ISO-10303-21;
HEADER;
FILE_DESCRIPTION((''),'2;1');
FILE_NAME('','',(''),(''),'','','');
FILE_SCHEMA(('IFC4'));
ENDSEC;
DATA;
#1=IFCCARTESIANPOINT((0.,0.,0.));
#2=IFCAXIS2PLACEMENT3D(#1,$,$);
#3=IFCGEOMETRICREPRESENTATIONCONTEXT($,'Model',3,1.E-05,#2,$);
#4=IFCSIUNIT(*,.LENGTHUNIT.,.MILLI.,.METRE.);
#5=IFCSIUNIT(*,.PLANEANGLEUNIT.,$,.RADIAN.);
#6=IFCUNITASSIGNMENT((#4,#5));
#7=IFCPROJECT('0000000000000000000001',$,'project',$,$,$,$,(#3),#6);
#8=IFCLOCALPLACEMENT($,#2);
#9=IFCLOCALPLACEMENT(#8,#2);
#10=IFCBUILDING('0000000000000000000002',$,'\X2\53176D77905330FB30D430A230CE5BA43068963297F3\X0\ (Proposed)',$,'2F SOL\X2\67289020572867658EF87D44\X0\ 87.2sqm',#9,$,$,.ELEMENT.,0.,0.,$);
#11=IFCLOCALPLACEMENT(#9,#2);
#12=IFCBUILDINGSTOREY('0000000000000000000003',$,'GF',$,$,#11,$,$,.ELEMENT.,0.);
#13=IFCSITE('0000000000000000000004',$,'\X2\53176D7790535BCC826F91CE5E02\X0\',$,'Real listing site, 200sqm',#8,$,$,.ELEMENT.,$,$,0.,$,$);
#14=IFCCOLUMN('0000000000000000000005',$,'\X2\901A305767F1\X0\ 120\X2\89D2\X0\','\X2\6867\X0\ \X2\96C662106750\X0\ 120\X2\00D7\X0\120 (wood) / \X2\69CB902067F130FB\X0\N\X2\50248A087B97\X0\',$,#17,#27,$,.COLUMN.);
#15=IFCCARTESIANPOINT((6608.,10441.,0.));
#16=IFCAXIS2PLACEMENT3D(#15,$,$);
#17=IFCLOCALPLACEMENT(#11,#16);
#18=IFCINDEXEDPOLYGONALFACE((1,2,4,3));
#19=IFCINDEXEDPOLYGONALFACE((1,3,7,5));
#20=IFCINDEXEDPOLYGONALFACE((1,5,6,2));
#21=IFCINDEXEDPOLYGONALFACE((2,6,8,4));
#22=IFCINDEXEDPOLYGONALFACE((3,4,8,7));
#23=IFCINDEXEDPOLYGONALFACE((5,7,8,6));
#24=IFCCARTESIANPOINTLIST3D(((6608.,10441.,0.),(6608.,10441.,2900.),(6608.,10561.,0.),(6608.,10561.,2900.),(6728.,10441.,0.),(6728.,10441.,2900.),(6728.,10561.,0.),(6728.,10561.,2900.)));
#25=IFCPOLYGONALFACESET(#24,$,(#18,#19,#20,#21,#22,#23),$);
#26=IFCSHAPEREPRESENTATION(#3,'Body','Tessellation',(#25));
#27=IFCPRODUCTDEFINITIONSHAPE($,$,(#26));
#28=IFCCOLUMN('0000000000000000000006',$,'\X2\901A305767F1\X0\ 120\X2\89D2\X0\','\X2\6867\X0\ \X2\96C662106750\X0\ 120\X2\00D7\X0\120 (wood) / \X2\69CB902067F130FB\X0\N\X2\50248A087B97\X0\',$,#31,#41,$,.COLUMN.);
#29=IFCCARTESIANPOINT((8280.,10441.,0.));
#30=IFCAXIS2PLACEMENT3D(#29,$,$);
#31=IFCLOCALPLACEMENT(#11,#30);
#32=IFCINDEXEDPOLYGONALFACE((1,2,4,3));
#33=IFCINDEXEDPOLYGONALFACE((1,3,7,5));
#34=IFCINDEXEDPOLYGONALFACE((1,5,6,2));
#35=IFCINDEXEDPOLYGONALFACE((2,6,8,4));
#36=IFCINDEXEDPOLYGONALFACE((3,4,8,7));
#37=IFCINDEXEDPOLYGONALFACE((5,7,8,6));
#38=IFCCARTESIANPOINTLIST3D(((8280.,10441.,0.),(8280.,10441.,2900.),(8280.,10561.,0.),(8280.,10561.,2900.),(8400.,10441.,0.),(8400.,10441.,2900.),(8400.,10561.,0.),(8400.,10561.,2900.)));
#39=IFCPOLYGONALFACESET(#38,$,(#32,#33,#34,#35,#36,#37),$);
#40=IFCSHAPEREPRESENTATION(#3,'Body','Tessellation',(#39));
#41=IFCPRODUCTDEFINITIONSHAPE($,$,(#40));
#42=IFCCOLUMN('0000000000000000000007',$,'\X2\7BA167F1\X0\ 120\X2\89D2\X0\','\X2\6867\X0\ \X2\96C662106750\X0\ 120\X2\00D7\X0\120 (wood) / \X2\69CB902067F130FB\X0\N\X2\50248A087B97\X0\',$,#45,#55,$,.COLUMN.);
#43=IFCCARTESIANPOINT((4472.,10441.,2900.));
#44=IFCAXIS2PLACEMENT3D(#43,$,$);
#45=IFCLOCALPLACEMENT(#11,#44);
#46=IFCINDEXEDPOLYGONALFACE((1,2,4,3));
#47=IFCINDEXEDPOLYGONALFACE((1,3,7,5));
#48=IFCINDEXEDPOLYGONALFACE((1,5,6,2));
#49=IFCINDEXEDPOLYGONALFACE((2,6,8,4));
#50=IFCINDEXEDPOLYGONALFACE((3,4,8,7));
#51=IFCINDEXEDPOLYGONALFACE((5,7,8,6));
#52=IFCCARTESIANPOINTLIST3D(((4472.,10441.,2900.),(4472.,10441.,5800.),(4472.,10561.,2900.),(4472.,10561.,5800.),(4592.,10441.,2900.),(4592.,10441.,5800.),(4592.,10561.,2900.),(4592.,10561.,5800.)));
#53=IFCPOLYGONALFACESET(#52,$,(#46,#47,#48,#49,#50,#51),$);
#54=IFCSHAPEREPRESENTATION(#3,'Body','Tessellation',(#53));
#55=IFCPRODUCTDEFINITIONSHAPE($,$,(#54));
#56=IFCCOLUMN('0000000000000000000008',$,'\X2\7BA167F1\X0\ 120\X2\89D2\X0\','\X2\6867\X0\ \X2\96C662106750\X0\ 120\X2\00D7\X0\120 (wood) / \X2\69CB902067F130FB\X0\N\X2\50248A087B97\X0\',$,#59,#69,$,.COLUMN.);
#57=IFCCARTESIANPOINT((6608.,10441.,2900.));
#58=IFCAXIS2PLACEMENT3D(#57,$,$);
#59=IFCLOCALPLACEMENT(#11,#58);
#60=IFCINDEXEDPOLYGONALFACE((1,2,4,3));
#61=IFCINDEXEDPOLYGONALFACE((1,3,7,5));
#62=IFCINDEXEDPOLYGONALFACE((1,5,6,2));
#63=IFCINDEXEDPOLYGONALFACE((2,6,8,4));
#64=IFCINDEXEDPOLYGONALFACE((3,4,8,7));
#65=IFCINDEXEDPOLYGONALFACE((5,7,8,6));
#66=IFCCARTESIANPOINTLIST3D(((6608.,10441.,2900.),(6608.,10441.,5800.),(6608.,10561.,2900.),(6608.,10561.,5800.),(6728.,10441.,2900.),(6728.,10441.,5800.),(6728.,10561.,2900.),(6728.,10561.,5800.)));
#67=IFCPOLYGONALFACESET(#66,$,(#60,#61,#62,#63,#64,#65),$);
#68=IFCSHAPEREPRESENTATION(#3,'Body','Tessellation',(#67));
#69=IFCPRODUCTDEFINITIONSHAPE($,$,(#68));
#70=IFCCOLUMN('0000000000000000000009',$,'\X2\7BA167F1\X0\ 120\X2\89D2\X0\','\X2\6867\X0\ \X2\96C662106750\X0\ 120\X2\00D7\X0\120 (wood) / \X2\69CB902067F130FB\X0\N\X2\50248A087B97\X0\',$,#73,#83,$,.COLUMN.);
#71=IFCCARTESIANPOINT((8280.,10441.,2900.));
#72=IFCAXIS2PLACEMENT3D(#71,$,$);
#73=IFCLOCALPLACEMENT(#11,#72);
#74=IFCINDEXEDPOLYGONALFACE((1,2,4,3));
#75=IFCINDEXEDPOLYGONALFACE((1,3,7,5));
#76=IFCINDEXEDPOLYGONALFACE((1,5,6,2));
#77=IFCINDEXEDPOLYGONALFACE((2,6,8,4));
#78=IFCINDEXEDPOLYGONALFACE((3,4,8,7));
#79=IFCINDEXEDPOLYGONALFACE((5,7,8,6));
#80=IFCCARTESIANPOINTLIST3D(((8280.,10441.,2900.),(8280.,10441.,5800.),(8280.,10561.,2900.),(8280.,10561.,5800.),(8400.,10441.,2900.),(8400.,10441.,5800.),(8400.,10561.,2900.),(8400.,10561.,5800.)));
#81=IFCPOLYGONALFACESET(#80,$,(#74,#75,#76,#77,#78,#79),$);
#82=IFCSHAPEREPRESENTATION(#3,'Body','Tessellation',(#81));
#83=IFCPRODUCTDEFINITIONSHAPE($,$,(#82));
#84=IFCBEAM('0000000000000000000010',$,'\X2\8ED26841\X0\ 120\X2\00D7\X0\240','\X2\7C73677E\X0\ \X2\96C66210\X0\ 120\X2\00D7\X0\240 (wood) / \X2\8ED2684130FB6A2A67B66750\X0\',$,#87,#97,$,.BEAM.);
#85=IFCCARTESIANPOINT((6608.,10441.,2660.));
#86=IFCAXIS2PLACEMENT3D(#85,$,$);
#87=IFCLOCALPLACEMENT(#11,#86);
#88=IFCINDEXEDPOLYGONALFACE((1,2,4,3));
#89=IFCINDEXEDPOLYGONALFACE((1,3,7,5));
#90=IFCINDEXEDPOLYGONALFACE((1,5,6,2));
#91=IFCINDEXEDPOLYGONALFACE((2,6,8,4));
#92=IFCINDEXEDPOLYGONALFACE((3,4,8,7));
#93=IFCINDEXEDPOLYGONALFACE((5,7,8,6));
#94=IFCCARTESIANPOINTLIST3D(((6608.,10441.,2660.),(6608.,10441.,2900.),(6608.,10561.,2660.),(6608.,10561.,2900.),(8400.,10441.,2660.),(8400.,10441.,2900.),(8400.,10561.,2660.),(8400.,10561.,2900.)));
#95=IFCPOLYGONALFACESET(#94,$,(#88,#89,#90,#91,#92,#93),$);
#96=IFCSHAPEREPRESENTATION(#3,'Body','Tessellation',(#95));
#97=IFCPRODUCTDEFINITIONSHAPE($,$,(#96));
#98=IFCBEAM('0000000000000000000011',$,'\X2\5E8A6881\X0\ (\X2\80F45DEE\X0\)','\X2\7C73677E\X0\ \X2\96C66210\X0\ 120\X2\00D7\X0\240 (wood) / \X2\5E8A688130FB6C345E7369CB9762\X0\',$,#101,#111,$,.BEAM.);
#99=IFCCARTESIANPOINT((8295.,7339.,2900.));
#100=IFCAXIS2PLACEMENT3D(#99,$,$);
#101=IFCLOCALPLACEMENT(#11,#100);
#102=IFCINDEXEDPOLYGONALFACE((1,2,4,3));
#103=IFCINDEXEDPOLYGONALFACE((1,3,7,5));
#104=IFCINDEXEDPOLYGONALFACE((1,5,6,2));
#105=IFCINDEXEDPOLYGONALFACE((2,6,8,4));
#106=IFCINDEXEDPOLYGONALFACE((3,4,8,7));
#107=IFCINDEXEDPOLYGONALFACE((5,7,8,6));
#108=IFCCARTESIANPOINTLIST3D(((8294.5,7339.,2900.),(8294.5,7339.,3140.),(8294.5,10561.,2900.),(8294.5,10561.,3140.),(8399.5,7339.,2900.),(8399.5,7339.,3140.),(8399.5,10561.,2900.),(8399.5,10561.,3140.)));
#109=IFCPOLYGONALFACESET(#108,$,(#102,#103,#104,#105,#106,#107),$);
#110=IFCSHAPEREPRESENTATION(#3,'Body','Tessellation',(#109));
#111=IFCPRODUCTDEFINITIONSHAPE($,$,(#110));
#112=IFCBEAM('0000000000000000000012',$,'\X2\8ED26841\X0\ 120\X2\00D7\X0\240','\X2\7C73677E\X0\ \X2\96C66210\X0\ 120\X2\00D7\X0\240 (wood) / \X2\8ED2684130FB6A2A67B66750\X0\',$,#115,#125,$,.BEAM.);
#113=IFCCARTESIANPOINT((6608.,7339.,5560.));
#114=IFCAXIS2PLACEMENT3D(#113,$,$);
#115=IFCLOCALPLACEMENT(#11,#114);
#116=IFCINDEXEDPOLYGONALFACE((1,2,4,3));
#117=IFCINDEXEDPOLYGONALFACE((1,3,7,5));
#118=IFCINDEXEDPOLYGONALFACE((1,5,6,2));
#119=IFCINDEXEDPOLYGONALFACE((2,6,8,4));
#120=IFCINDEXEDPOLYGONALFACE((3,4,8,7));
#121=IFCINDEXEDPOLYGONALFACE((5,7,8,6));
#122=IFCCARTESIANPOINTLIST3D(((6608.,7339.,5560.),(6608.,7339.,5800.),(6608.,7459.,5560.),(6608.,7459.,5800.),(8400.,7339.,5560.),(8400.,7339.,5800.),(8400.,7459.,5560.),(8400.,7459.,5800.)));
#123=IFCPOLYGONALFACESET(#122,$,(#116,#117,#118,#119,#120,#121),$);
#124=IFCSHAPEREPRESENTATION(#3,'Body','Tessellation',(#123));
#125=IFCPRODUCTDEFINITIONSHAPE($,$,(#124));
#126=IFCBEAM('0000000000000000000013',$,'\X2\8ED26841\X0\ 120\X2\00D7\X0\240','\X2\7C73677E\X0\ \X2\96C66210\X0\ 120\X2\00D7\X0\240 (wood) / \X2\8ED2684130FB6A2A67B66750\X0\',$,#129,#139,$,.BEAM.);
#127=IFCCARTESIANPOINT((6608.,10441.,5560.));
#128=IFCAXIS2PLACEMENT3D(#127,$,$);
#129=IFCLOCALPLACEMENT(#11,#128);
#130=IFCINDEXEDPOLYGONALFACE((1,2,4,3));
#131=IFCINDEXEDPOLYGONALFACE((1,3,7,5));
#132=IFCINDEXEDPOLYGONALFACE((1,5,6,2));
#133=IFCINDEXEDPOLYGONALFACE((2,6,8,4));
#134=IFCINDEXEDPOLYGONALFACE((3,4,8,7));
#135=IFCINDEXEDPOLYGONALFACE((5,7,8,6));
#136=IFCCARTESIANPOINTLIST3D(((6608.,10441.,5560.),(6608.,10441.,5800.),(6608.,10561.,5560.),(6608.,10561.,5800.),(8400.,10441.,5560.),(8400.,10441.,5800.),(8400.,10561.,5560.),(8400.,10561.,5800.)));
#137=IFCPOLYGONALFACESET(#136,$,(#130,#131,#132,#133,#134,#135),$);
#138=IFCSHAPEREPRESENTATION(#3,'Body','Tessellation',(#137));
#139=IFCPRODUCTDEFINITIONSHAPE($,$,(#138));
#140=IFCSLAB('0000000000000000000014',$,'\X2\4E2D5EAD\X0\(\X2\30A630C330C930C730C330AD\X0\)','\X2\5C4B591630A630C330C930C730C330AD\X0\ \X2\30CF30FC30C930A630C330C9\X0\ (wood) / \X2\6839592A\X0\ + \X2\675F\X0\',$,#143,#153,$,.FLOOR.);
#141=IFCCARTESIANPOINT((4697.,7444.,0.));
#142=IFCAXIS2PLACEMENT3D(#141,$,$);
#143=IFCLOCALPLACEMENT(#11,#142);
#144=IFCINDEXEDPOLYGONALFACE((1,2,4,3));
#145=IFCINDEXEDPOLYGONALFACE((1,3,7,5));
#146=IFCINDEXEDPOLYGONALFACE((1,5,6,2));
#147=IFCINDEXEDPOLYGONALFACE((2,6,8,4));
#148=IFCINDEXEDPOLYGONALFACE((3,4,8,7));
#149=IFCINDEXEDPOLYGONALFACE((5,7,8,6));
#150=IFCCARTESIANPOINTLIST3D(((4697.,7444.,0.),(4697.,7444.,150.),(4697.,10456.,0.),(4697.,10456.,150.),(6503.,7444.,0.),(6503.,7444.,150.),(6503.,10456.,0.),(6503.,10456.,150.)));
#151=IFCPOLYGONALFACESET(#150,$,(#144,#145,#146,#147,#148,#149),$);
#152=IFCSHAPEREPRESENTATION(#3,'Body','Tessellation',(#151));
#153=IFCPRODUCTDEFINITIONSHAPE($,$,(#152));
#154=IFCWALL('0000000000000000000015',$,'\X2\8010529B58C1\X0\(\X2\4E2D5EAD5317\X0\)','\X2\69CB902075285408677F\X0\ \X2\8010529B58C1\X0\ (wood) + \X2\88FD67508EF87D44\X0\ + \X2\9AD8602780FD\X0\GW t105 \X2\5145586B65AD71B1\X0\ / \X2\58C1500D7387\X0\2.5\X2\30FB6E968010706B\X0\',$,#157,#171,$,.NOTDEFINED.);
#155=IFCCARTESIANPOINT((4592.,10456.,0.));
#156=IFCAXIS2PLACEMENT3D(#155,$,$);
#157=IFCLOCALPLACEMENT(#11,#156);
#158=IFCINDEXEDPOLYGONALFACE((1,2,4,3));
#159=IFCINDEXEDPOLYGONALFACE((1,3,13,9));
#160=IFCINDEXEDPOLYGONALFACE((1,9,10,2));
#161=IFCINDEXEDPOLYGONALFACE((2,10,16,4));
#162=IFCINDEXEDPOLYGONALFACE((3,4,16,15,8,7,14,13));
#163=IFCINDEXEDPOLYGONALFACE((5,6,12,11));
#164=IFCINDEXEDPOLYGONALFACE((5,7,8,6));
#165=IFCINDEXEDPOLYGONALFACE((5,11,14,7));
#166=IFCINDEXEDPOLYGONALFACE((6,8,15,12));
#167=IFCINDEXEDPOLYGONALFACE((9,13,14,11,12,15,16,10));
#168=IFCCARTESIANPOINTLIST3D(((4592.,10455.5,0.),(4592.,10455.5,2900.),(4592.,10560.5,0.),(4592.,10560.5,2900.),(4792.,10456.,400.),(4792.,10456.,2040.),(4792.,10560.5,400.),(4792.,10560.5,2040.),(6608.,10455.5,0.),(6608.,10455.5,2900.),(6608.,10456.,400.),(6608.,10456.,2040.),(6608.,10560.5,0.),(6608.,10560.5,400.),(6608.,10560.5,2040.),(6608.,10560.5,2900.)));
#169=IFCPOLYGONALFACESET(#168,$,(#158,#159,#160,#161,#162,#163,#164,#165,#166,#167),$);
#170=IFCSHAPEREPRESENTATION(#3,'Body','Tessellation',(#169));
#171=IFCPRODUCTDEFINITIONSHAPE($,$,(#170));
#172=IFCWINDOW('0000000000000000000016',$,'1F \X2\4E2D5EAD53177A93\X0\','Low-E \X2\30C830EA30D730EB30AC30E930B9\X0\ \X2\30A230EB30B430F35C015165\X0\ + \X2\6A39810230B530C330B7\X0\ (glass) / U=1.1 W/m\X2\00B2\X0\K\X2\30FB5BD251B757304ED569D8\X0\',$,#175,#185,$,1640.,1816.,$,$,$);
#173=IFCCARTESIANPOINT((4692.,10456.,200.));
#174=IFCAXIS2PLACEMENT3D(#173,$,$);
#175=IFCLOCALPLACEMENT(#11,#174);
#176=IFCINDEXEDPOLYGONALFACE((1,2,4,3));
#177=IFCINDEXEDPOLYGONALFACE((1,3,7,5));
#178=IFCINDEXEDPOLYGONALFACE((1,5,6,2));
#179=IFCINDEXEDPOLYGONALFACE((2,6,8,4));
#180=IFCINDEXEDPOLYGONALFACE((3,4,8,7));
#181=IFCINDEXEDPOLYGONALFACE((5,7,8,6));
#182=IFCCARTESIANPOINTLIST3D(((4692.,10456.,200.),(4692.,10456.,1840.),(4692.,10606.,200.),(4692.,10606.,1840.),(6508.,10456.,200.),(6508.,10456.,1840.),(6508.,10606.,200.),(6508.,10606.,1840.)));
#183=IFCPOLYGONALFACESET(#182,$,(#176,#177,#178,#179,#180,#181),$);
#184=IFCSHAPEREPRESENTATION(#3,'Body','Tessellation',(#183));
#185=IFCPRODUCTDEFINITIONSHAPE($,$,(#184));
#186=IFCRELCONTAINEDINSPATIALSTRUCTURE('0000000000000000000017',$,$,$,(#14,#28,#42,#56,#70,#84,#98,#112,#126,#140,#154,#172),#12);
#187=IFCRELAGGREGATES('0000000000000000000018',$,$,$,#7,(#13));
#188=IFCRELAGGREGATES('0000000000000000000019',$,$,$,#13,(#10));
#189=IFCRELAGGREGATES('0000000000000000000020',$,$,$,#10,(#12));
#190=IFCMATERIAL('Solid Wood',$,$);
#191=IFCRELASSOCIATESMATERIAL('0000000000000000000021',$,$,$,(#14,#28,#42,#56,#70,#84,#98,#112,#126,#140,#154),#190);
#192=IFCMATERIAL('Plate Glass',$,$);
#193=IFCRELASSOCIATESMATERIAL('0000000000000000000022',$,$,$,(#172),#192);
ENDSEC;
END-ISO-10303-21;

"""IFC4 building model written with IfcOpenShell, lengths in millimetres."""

from ifc_helpers import new_model, si_unit, frame, frame_2d, origin, place, context, project, spatial, rectangle, extrude, material, element, fill, save


model = new_model("IFC4")

# Units and contexts
model_context = context("Model", 3, precision=1e-05, world=origin())
ifc_project = project(units=[si_unit("LENGTHUNIT", "METRE", prefix="MILLI"), si_unit("PLANEANGLEUNIT", "RADIAN")], contexts=[model_context])

# Site, building, storey
site_placement = place(None, origin())
site = spatial("IfcSite", under=ifc_project, at=site_placement, Name="北海道富良野市", ObjectType="Real listing site, 200sqm", CompositionType="ELEMENT", RefElevation=0.0)
building_placement = place(site_placement, origin())
building = spatial("IfcBuilding", under=site, at=building_placement, Name="北海道・ピアノ室と防音 (Proposed)", ObjectType="2F SOL木造在来軸組 87.2sqm", CompositionType="ELEMENT", ElevationOfRefHeight=0.0, ElevationOfTerrain=0.0)
storey_placement = place(building_placement, origin())
storey = spatial("IfcBuildingStorey", under=building, at=storey_placement, Name="GF", CompositionType="ELEMENT", Elevation=0.0)

# Columns
ifc_material_1 = material(Name="Solid Wood")
column_1_placement = place(storey_placement, frame((6608.0, 10441.0, 0.0)))
element("IfcColumn", 1, at=column_1_placement, inside=storey, material=ifc_material_1, Name="通し柱 120角", Description="桧 集成材 120×120 (wood) / 構造柱・N値計算", PredefinedType="COLUMN", context=model_context, shape_type="SweptSolid", body=[
    extrude(rectangle(XDim=120.0, YDim=120.0, at=frame_2d((60.0, 60.0))), frame((6608.0, 10441.0, 0.0)), (0.0, 0.0, 1.0), 2900.0),
])
column_2_placement = place(storey_placement, frame((8280.0, 10441.0, 0.0)))
element("IfcColumn", 2, at=column_2_placement, inside=storey, material=ifc_material_1, Name="通し柱 120角", Description="桧 集成材 120×120 (wood) / 構造柱・N値計算", PredefinedType="COLUMN", context=model_context, shape_type="SweptSolid", body=[
    extrude(rectangle(XDim=120.0, YDim=120.0, at=frame_2d((60.0, 60.0))), frame((8280.0, 10441.0, 0.0)), (0.0, 0.0, 1.0), 2900.0),
])
column_3_placement = place(storey_placement, frame((4472.0, 10441.0, 2900.0)))
element("IfcColumn", 3, at=column_3_placement, inside=storey, material=ifc_material_1, Name="管柱 120角", Description="桧 集成材 120×120 (wood) / 構造柱・N値計算", PredefinedType="COLUMN", context=model_context, shape_type="SweptSolid", body=[
    extrude(rectangle(XDim=120.0, YDim=120.0, at=frame_2d((60.0, 60.0))), frame((4472.0, 10441.0, 2900.0)), (0.0, 0.0, 1.0), 2900.0),
])
column_4_placement = place(storey_placement, frame((6608.0, 10441.0, 2900.0)))
element("IfcColumn", 4, at=column_4_placement, inside=storey, material=ifc_material_1, Name="管柱 120角", Description="桧 集成材 120×120 (wood) / 構造柱・N値計算", PredefinedType="COLUMN", context=model_context, shape_type="SweptSolid", body=[
    extrude(rectangle(XDim=120.0, YDim=120.0, at=frame_2d((60.0, 60.0))), frame((6608.0, 10441.0, 2900.0)), (0.0, 0.0, 1.0), 2900.0),
])
column_5_placement = place(storey_placement, frame((8280.0, 10441.0, 2900.0)))
element("IfcColumn", 5, at=column_5_placement, inside=storey, material=ifc_material_1, Name="管柱 120角", Description="桧 集成材 120×120 (wood) / 構造柱・N値計算", PredefinedType="COLUMN", context=model_context, shape_type="SweptSolid", body=[
    extrude(rectangle(XDim=120.0, YDim=120.0, at=frame_2d((60.0, 60.0))), frame((8280.0, 10441.0, 2900.0)), (0.0, 0.0, 1.0), 2900.0),
])

# Beams
beam_1_placement = place(storey_placement, frame((6608.0, 10441.0, 2660.0)))
element("IfcBeam", 6, at=beam_1_placement, inside=storey, material=ifc_material_1, Name="軒桁 120×240", Description="米松 集成 120×240 (wood) / 軒桁・横架材", PredefinedType="BEAM", context=model_context, shape_type="SweptSolid", body=[
    extrude(rectangle(XDim=1792.0, YDim=120.0, at=frame_2d((896.0, 60.0))), frame((6608.0, 10441.0, 2660.0)), (0.0, 0.0, 1.0), 240.0),
])
beam_2_placement = place(storey_placement, frame((8295.0, 7339.0, 2900.0)))
element("IfcBeam", 7, at=beam_2_placement, inside=storey, material=ifc_material_1, Name="床梁 (胴差)", Description="米松 集成 120×240 (wood) / 床梁・水平構面", PredefinedType="BEAM", context=model_context, shape_type="SweptSolid", body=[
    extrude(rectangle(XDim=105.0, YDim=3222.0, at=frame_2d((52.0, 1611.0))), frame((8295.0, 7339.0, 2900.0)), (0.0, 0.0, 1.0), 240.0),
])
beam_3_placement = place(storey_placement, frame((6608.0, 7339.0, 5560.0)))
element("IfcBeam", 8, at=beam_3_placement, inside=storey, material=ifc_material_1, Name="軒桁 120×240", Description="米松 集成 120×240 (wood) / 軒桁・横架材", PredefinedType="BEAM", context=model_context, shape_type="SweptSolid", body=[
    extrude(rectangle(XDim=1792.0, YDim=120.0, at=frame_2d((896.0, 60.0))), frame((6608.0, 7339.0, 5560.0)), (0.0, 0.0, 1.0), 240.0),
])
beam_4_placement = place(storey_placement, frame((6608.0, 10441.0, 5560.0)))
element("IfcBeam", 9, at=beam_4_placement, inside=storey, material=ifc_material_1, Name="軒桁 120×240", Description="米松 集成 120×240 (wood) / 軒桁・横架材", PredefinedType="BEAM", context=model_context, shape_type="SweptSolid", body=[
    extrude(rectangle(XDim=1792.0, YDim=120.0, at=frame_2d((896.0, 60.0))), frame((6608.0, 10441.0, 5560.0)), (0.0, 0.0, 1.0), 240.0),
])

# Slab
slab_placement = place(storey_placement, frame((4697.0, 7444.0, 0.0)))
element("IfcSlab", 10, at=slab_placement, inside=storey, material=ifc_material_1, Name="中庭(ウッドデッキ)", Description="屋外ウッドデッキ ハードウッド (wood) / 根太 + 束", PredefinedType="FLOOR", context=model_context, shape_type="SweptSolid", body=[
    extrude(rectangle(XDim=1806.0, YDim=3012.0, at=frame_2d((903.0, 1506.0))), frame((4697.0, 7444.0, 0.0)), (0.0, 0.0, 1.0), 150.0),
])

# Wall, opening, window
wall_1_placement = place(storey_placement, frame((4592.0, 10456.0, 0.0)))
wall_1 = element("IfcWall", 11, at=wall_1_placement, inside=storey, material=ifc_material_1, Name="耐力壁(中庭北)", Description="構造用合板 耐力壁 (wood) + 製材軸組 + 高性能GW t105 充填断熱 / 壁倍率2.5・準耐火", PredefinedType="NOTDEFINED", context=model_context, shape_type="SweptSolid", body=[
    extrude(rectangle(XDim=2016.0, YDim=105.0, at=frame_2d((1008.0, 52.0))), frame((4592.0, 10456.0, 0.0)), (0.0, 0.0, 1.0), 2900.0),
])
opening_1_placement = place(storey_placement, frame((4692.0, 10456.0, 200.0)))
opening_1 = element("IfcOpeningElement", 12, at=opening_1_placement, cuts=wall_1, PredefinedType="NOTDEFINED", context=model_context, shape_type="SweptSolid", body=[
    extrude(rectangle(XDim=1816.0, YDim=150.0, at=frame_2d((908.0, 75.0))), frame((4692.0, 10456.0, 200.0)), (0.0, 0.0, 1.0), 1640.0),
])
ifc_material_2 = material(Name="Plate Glass")
window_1_placement = place(storey_placement, frame((4692.0, 10456.0, 200.0)))
window_1 = element("IfcWindow", 13, at=window_1_placement, inside=storey, material=ifc_material_2, Name="1F 中庭北窓", Description="Low-E トリプルガラス アルゴン封入 + 樹脂サッシ (glass) / U=1.1 W/m²K・寒冷地仕様", OverallHeight=1640.0, OverallWidth=1816.0, context=model_context, shape_type="SweptSolid", body=[
    extrude(rectangle(XDim=1816.0, YDim=150.0, at=frame_2d((908.0, 75.0))), frame((4692.0, 10456.0, 200.0)), (0.0, 0.0, 1.0), 1640.0),
])
fill(opening_1, window_1)

save(model, "model.ifc")
